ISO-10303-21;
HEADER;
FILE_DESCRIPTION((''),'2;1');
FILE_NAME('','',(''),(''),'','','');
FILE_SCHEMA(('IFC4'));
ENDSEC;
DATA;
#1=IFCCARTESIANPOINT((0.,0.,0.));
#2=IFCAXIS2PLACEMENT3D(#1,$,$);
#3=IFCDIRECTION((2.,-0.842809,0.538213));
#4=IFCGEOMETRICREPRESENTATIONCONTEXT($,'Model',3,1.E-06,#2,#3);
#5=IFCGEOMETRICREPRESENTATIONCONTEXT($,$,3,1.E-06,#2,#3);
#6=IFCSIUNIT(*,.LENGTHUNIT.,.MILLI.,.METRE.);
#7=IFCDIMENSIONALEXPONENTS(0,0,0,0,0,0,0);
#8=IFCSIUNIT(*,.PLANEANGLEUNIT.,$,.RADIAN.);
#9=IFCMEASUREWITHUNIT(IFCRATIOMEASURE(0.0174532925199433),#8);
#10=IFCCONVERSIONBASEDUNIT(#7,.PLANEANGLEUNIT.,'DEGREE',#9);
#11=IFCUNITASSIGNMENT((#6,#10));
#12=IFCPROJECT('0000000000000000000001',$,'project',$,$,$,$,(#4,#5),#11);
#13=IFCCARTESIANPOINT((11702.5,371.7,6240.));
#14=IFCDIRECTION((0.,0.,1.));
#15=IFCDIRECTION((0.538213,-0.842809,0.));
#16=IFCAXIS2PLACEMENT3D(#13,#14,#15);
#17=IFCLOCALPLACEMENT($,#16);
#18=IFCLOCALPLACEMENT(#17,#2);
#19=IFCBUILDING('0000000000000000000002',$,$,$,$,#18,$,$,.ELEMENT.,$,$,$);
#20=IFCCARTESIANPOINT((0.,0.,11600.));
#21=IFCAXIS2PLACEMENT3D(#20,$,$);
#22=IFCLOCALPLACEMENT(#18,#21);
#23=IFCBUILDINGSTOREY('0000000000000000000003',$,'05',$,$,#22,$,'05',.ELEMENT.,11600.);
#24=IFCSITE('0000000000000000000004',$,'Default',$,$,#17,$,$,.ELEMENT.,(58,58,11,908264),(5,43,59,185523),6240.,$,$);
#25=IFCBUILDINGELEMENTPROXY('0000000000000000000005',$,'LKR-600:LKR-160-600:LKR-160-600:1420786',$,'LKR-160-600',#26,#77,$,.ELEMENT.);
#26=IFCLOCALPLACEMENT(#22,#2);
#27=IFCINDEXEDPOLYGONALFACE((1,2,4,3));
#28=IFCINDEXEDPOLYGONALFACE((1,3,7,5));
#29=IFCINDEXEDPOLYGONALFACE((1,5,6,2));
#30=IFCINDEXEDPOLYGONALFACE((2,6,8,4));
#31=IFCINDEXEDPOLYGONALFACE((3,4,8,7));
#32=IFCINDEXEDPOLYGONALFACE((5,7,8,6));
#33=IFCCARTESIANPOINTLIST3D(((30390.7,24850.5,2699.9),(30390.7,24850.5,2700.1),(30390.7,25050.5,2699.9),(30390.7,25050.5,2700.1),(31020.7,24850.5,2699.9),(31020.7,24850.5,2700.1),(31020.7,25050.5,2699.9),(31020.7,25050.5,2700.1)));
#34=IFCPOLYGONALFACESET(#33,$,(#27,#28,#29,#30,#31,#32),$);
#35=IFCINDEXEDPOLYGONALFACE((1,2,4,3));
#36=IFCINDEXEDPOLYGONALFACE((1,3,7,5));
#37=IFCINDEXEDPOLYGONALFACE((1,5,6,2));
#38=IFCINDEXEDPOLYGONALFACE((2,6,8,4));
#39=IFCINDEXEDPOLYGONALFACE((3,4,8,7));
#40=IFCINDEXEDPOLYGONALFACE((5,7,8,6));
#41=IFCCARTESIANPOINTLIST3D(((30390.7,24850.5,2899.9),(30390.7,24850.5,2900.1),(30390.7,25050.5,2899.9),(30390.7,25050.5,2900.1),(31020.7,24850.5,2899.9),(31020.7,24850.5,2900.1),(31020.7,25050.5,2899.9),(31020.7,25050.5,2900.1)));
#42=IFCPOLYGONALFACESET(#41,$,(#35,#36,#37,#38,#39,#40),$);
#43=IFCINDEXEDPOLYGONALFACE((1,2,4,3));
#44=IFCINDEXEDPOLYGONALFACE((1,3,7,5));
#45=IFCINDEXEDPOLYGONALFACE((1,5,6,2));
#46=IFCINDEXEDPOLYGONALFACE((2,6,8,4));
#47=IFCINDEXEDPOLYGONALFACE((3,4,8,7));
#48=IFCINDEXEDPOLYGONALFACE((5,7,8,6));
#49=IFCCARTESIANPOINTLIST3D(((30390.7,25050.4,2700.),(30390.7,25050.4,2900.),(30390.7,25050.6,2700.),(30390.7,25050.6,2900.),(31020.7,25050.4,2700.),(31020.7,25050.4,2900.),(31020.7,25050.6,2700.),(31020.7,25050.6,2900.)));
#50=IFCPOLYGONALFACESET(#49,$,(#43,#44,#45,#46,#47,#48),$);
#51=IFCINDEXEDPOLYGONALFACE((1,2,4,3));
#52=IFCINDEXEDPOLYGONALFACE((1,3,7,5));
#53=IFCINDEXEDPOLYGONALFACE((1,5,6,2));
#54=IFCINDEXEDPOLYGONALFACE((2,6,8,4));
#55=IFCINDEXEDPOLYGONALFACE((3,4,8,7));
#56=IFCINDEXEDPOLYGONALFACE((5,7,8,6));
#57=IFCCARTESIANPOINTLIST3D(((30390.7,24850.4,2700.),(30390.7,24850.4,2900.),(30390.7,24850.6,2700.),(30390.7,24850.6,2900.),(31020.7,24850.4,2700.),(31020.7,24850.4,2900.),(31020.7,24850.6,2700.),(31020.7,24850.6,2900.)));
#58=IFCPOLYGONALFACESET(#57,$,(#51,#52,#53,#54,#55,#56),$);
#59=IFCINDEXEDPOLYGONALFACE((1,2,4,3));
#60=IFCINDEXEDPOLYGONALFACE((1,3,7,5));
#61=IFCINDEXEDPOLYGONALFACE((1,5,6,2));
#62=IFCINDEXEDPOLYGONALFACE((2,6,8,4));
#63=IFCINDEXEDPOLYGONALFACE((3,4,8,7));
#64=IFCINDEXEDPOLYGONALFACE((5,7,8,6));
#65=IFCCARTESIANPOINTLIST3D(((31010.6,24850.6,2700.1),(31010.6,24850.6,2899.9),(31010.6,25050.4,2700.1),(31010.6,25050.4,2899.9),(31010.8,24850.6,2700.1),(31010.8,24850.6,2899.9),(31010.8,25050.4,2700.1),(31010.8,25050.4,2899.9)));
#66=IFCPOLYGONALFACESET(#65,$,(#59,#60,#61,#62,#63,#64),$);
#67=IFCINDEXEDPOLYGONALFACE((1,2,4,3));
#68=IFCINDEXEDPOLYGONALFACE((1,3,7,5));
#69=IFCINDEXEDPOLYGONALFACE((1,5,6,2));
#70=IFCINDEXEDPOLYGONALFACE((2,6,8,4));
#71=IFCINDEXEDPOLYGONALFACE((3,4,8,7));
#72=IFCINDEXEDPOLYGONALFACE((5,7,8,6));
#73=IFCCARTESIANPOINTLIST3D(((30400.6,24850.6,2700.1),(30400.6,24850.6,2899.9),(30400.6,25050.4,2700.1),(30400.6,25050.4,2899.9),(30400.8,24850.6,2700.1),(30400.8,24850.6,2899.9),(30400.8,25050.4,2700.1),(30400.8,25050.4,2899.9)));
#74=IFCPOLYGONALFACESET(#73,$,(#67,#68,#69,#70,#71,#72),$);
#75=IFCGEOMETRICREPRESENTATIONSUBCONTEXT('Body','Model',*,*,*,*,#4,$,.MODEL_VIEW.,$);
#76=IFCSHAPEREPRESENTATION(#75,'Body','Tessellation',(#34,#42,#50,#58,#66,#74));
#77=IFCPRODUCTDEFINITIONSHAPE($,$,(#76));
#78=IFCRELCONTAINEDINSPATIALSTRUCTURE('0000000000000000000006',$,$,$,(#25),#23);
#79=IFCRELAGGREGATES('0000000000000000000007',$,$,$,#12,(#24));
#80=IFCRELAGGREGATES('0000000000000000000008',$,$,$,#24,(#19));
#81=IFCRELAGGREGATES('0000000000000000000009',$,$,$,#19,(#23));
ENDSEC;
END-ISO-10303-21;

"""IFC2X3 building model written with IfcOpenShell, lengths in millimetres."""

from ifc_helpers import new_model, entity, si_unit, converted_unit, direction, frame, frame_2d, origin, origin_2d_with_axis, place, context, subcontext, project, spatial, rectangle, extrude, source, transform, mapped, element, save


model = new_model("IFC2X3")

# Units and contexts
model_context = context("Model", 3, precision=1e-06, world=origin(), true_north=direction((2.0, -0.842809, 0.538213)))
context_of_model = context(None, 3, precision=1e-06, world=origin(), true_north=direction((2.0, -0.842809, 0.538213)))
body_context = subcontext(model_context, "Body", "Model", "MODEL_VIEW")
ifc_project = project(units=[si_unit("LENGTHUNIT", "METRE", prefix="MILLI"), converted_unit("PLANEANGLEUNIT", "DEGREE", entity("IfcRatioMeasure", 0.0174532925199433), si_unit("PLANEANGLEUNIT", "RADIAN"), dimensions=[0, 0, 0, 0, 0, 0, 0])], contexts=[model_context, context_of_model])

# Site, building, storey
site_placement = place(None, frame((11702.5, 371.7, 6240.0), z_axis=(0.0, 0.0, 1.0), x_axis=(0.538213, -0.842809, 0.0)))
site = spatial("IfcSite", under=ifc_project, at=site_placement, Name="Default", CompositionType="ELEMENT", RefLatitude=(58, 58, 11, 908264), RefLongitude=(5, 43, 59, 185523), RefElevation=6240.0)
building_placement = place(site_placement, origin())
building = spatial("IfcBuilding", under=site, at=building_placement, CompositionType="ELEMENT")
storey_placement = place(building_placement, frame((0.0, 0.0, 11600.0)))
storey = spatial("IfcBuildingStorey", under=building, at=storey_placement, Name="05", LongName="05", CompositionType="ELEMENT", Elevation=11600.0)

# Building element proxy
shared_shape_1 = source(origin(), body_context, "Body", "SweptSolid", [
    extrude(rectangle(XDim=200.0, YDim=630.0, at=origin_2d_with_axis()), frame((0.0, 0.0, -100.1), z_axis=(0.0, 0.0, 1.0), x_axis=(0.0, -1.0, 0.0)), (0.0, 0.0, 1.0), 0.2),
    extrude(rectangle(XDim=200.0, YDim=630.0, at=origin_2d_with_axis()), frame((0.0, 0.0, 99.9), z_axis=(0.0, 0.0, 1.0), x_axis=(0.0, -1.0, 0.0)), (0.0, 0.0, 1.0), 0.2),
    extrude(rectangle(XDim=0.2, YDim=630.0, at=frame_2d((0.0, 0.0), x_axis=(1.0, 0.0))), frame((0.0, 100.0, -100.0), z_axis=(0.0, 0.0, 1.0), x_axis=(0.0, 1.0, 0.0)), (0.0, 0.0, 1.0), 200.0),
    extrude(rectangle(XDim=0.2, YDim=630.0, at=frame_2d((0.0, 0.0), x_axis=(1.0, 0.0))), frame((0.0, -100.0, -100.0), z_axis=(0.0, 0.0, 1.0), x_axis=(0.0, 1.0, 0.0)), (0.0, 0.0, 1.0), 200.0),
    extrude(rectangle(XDim=0.2, YDim=199.8, at=frame_2d((0.0, 0.0), x_axis=(1.0, 0.0))), frame((305.0, 0.0, -99.9)), (0.0, 0.0, 1.0), 199.8),
    extrude(rectangle(XDim=0.2, YDim=199.8, at=frame_2d((0.0, 0.0), x_axis=(1.0, 0.0))), frame((-305.0, 0.0, -99.9)), (0.0, 0.0, 1.0), 199.8),
])
proxy_1_placement = place(storey_placement, frame((30705.7, 24950.5, 2800.0)))
element("IfcBuildingElementProxy", 1, at=proxy_1_placement, inside=storey, Name="LKR-600:LKR-160-600:LKR-160-600:1420786", ObjectType="LKR-160-600", CompositionType="ELEMENT", context=body_context, shape_type="MappedRepresentation", body=[
    mapped(shared_shape_1, transform((0.0, 0.0, 0.0), scale=1.0)),
])

save(model, "model.ifc")
